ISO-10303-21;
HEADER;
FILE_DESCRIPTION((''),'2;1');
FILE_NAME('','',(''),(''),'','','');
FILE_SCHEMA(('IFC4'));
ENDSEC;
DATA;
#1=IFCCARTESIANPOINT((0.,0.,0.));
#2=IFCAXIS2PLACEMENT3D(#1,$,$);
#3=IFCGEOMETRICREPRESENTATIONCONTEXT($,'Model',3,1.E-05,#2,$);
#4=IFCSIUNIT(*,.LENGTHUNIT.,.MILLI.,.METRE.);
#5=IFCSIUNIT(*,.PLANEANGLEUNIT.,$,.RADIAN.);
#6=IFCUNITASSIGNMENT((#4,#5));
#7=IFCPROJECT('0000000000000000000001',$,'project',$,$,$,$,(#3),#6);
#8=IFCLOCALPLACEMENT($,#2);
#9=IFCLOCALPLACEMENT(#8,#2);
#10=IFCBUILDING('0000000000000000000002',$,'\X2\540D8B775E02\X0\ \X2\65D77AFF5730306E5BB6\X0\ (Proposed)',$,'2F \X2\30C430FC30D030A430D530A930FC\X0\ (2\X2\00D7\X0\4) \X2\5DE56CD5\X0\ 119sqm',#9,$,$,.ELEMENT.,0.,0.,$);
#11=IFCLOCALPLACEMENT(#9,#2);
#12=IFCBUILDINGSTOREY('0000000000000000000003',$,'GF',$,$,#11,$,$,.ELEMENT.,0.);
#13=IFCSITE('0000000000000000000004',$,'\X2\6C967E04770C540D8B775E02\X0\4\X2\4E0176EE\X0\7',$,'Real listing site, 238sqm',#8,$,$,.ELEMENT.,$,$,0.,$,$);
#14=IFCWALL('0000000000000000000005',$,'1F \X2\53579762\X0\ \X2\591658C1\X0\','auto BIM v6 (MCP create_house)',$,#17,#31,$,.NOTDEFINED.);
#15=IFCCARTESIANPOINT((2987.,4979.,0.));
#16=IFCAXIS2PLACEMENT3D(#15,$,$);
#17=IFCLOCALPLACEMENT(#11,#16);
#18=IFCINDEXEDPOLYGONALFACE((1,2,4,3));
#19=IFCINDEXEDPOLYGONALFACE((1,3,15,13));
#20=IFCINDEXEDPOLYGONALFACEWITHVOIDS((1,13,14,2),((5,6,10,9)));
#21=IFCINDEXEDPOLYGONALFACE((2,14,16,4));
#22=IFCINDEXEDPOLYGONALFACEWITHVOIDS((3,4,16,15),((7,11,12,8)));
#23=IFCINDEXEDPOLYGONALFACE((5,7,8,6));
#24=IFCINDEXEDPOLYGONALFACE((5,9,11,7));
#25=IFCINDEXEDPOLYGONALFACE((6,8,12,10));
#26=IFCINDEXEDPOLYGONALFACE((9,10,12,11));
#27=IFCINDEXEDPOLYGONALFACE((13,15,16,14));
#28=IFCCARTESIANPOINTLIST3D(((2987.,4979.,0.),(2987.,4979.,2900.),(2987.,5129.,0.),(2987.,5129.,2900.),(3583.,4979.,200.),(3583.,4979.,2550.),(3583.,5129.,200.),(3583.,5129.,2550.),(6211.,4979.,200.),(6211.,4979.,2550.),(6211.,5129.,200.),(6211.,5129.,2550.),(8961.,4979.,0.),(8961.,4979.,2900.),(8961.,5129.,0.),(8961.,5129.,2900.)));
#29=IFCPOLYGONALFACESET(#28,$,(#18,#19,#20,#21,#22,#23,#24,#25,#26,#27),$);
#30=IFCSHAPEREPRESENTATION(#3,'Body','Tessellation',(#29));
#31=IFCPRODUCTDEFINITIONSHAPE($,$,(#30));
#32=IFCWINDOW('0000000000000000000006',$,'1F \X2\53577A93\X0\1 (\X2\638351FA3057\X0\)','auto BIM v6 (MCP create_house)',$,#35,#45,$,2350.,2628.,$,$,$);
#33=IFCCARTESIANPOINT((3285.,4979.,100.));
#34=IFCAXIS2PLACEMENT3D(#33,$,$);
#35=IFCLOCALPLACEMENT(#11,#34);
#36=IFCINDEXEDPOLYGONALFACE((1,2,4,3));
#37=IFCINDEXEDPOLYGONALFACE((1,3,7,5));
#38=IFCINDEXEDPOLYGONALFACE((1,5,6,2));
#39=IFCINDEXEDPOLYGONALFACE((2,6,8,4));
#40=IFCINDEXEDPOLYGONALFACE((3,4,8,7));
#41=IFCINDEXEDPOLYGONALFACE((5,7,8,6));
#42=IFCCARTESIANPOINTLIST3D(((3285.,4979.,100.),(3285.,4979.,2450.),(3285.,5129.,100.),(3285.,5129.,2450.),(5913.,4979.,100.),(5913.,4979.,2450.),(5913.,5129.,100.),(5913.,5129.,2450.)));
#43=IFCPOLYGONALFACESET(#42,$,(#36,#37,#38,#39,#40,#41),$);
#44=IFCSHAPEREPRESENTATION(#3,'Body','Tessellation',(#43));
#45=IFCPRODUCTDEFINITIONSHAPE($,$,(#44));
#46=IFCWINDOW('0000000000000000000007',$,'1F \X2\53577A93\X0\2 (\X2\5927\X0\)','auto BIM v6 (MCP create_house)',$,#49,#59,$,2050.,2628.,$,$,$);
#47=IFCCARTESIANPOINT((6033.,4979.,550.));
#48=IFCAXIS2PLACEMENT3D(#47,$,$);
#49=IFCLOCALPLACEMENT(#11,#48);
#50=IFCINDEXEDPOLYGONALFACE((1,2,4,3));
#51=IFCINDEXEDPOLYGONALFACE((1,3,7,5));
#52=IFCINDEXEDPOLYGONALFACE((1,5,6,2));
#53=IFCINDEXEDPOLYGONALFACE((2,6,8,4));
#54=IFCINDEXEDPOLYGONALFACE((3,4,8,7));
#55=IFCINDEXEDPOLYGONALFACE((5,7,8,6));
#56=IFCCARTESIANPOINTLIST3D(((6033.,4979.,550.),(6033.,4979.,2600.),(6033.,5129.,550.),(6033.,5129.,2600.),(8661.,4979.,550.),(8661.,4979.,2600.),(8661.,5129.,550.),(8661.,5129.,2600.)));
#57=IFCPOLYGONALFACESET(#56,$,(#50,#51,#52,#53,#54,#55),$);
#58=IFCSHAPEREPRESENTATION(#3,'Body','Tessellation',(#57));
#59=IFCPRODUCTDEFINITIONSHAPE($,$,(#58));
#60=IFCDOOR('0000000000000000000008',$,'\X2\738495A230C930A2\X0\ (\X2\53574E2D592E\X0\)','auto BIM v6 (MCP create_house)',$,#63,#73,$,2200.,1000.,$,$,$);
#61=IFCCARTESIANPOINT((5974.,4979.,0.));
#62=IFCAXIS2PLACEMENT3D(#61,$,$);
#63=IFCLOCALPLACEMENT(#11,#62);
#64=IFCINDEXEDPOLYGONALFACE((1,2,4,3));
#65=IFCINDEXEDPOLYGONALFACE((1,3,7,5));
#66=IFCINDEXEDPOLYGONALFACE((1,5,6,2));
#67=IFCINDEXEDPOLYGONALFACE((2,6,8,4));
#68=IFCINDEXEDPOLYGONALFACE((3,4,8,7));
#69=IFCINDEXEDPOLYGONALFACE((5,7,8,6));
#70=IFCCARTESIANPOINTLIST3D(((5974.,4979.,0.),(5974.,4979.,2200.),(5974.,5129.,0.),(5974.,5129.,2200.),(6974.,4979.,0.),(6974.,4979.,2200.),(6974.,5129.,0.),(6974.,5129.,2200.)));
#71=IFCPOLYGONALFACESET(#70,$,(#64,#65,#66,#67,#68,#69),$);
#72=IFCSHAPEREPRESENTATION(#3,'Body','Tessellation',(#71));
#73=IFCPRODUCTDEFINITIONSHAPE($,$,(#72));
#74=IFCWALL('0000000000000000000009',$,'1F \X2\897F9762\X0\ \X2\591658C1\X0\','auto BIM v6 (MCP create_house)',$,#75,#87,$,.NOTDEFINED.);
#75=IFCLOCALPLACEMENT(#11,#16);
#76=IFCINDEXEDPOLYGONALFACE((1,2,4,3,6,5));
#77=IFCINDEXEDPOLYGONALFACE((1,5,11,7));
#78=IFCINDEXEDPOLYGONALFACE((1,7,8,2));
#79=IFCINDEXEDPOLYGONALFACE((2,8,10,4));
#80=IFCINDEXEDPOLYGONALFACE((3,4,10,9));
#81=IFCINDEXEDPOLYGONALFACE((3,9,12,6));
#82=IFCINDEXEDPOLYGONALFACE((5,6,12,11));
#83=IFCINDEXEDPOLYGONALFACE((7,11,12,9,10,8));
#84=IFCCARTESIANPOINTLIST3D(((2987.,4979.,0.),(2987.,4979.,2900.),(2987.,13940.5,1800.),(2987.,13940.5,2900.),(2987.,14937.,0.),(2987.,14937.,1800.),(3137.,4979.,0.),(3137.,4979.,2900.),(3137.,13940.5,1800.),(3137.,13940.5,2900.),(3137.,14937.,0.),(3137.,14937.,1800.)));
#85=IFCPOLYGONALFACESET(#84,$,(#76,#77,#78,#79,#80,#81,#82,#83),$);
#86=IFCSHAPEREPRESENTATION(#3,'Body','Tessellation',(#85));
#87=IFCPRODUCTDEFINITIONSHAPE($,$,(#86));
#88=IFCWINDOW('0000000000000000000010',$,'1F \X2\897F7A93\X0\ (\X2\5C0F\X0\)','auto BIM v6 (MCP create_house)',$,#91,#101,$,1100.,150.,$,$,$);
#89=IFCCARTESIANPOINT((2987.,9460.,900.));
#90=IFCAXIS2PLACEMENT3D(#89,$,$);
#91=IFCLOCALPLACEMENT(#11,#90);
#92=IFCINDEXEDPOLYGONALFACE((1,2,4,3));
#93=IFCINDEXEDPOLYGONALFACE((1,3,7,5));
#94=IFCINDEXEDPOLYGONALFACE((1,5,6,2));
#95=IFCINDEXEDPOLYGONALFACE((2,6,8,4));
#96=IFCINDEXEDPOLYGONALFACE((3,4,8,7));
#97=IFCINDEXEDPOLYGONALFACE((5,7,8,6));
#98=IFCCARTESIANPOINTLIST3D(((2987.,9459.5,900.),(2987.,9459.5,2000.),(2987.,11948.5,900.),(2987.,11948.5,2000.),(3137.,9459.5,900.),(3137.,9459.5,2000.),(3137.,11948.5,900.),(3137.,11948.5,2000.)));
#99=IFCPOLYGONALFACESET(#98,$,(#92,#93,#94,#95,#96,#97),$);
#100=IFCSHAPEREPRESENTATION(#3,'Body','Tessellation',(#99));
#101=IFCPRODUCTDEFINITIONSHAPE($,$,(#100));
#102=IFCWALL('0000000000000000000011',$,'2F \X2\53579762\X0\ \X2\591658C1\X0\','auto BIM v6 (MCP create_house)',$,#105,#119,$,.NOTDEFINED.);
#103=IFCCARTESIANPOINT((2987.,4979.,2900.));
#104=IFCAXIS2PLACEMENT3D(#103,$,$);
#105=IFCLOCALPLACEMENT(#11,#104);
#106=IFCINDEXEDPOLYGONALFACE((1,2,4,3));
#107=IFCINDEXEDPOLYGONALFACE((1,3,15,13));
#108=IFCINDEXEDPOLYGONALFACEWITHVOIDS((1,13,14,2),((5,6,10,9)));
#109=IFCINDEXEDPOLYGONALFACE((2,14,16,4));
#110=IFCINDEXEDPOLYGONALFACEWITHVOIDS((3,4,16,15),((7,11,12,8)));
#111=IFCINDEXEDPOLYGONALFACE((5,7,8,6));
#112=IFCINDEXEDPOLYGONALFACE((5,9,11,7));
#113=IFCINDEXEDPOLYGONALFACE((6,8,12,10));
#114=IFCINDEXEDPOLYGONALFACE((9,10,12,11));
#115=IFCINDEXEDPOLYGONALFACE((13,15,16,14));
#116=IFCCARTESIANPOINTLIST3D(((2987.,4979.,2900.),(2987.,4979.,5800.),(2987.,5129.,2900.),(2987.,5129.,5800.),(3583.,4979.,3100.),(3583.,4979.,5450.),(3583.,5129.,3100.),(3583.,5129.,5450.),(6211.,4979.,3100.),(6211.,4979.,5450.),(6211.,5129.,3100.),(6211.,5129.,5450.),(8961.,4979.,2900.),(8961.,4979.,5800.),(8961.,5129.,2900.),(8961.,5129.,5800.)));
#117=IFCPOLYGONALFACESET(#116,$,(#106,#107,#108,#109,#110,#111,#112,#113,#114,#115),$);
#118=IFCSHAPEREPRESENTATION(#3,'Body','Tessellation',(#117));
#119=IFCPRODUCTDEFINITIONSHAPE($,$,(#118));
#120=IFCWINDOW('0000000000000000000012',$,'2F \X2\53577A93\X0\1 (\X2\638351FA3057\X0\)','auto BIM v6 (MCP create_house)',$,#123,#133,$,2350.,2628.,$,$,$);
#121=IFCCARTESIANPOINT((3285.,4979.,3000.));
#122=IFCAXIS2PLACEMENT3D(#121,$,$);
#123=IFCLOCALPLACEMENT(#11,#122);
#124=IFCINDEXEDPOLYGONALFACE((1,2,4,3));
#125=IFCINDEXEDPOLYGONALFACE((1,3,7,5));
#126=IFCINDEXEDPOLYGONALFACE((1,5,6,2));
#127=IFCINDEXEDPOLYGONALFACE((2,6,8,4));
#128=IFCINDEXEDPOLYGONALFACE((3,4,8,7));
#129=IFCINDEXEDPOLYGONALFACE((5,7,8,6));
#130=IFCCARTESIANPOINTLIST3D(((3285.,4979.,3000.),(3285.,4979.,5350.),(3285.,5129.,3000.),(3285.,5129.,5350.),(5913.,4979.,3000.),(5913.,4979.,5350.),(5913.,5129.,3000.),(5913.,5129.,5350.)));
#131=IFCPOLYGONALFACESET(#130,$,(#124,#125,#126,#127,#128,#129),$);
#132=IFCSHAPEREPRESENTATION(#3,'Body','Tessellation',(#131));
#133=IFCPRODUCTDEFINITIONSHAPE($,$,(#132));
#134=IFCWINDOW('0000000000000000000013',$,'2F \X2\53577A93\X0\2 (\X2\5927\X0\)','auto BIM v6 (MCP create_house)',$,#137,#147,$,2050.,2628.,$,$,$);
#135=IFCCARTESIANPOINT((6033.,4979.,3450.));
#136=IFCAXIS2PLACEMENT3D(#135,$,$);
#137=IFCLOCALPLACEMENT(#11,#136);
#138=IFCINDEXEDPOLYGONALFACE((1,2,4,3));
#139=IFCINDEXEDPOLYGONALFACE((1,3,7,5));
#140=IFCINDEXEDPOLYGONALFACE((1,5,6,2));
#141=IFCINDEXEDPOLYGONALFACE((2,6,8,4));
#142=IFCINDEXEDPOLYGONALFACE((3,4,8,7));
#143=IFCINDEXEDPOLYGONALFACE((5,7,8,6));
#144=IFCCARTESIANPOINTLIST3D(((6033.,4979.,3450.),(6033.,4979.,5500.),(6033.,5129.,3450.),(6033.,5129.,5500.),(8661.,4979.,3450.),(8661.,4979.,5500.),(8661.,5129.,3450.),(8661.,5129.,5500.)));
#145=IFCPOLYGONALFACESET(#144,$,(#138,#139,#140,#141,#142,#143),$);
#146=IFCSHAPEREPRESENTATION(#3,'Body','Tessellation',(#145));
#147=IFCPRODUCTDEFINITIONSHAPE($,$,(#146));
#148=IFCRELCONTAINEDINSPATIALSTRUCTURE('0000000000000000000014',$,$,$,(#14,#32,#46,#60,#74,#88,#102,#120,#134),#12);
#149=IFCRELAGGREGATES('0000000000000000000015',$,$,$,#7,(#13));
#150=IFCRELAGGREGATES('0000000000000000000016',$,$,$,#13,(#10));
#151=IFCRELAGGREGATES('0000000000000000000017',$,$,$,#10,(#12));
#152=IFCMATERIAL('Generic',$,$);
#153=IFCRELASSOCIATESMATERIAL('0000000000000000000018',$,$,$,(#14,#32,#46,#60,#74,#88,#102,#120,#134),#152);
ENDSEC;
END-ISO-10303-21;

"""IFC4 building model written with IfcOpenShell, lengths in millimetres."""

from ifc_helpers import new_model, si_unit, frame, frame_2d, origin, place, context, project, spatial, rectangle, extrude, material, element, fill, save


model = new_model("IFC4")

# Units and contexts
model_context = context("Model", 3, precision=1e-05, world=origin())
ifc_project = project(units=[si_unit("LENGTHUNIT", "METRE", prefix="MILLI"), si_unit("PLANEANGLEUNIT", "RADIAN")], contexts=[model_context])

# Site, building, storey
site_placement = place(None, origin())
site = spatial("IfcSite", under=ifc_project, at=site_placement, Name="沖縄県名護市4丁目7", ObjectType="Real listing site, 238sqm", CompositionType="ELEMENT", RefElevation=0.0)
building_placement = place(site_placement, origin())
building = spatial("IfcBuilding", under=site, at=building_placement, Name="名護市 旗竿地の家 (Proposed)", ObjectType="2F ツーバイフォー (2×4) 工法 119sqm", CompositionType="ELEMENT", ElevationOfRefHeight=0.0, ElevationOfTerrain=0.0)
storey_placement = place(building_placement, origin())
storey = spatial("IfcBuildingStorey", under=building, at=storey_placement, Name="GF", CompositionType="ELEMENT", Elevation=0.0)

# Shared definitions
ifc_material = material(Name="Generic")

# Wall, openings, windows, door
wall_1_placement = place(storey_placement, frame((2987.0, 4979.0, 0.0)))
wall_1 = element("IfcWall", 1, at=wall_1_placement, inside=storey, material=ifc_material, Name="1F 南面 外壁", Description="auto BIM v6 (MCP create_house)", PredefinedType="NOTDEFINED", context=model_context, shape_type="SweptSolid", body=[
    extrude(rectangle(XDim=5974.0, YDim=150.0, at=frame_2d((2987.0, 75.0))), frame((2987.0, 4979.0, 0.0)), (0.0, 0.0, 1.0), 2900.0),
])
opening_1_placement = place(storey_placement, frame((3285.0, 4979.0, 100.0)))
opening_1 = element("IfcOpeningElement", 2, at=opening_1_placement, cuts=wall_1, PredefinedType="NOTDEFINED", context=model_context, shape_type="SweptSolid", body=[
    extrude(rectangle(XDim=2628.0, YDim=150.0, at=frame_2d((1314.0, 75.0))), frame((3285.0, 4979.0, 100.0)), (0.0, 0.0, 1.0), 2350.0),
])
opening_2_placement = place(storey_placement, frame((6033.0, 4979.0, 550.0)))
opening_2 = element("IfcOpeningElement", 3, at=opening_2_placement, cuts=wall_1, PredefinedType="NOTDEFINED", context=model_context, shape_type="SweptSolid", body=[
    extrude(rectangle(XDim=2628.0, YDim=150.0, at=frame_2d((1314.0, 75.0))), frame((6033.0, 4979.0, 550.0)), (0.0, 0.0, 1.0), 2050.0),
])
opening_3_placement = place(storey_placement, frame((5974.0, 4979.0, 0.0)))
opening_3 = element("IfcOpeningElement", 4, at=opening_3_placement, cuts=wall_1, PredefinedType="NOTDEFINED", context=model_context, shape_type="SweptSolid", body=[
    extrude(rectangle(XDim=1000.0, YDim=150.0, at=frame_2d((500.0, 75.0))), frame((5974.0, 4979.0, 0.0)), (0.0, 0.0, 1.0), 2200.0),
])
window_1_placement = place(storey_placement, frame((3285.0, 4979.0, 100.0)))
window_1 = element("IfcWindow", 5, at=window_1_placement, inside=storey, material=ifc_material, Name="1F 南窓1 (掃出し)", Description="auto BIM v6 (MCP create_house)", OverallHeight=2350.0, OverallWidth=2628.0, context=model_context, shape_type="SweptSolid", body=[
    extrude(rectangle(XDim=2628.0, YDim=150.0, at=frame_2d((1314.0, 75.0))), frame((3285.0, 4979.0, 100.0)), (0.0, 0.0, 1.0), 2350.0),
])
fill(opening_1, window_1)
window_2_placement = place(storey_placement, frame((6033.0, 4979.0, 550.0)))
window_2 = element("IfcWindow", 6, at=window_2_placement, inside=storey, material=ifc_material, Name="1F 南窓2 (大)", Description="auto BIM v6 (MCP create_house)", OverallHeight=2050.0, OverallWidth=2628.0, context=model_context, shape_type="SweptSolid", body=[
    extrude(rectangle(XDim=2628.0, YDim=150.0, at=frame_2d((1314.0, 75.0))), frame((6033.0, 4979.0, 550.0)), (0.0, 0.0, 1.0), 2050.0),
])
fill(opening_2, window_2)
door_placement = place(storey_placement, frame((5974.0, 4979.0, 0.0)))
door = element("IfcDoor", 7, at=door_placement, inside=storey, material=ifc_material, Name="玄関ドア (南中央)", Description="auto BIM v6 (MCP create_house)", OverallHeight=2200.0, OverallWidth=1000.0, context=model_context, shape_type="SweptSolid", body=[
    extrude(rectangle(XDim=1000.0, YDim=150.0, at=frame_2d((500.0, 75.0))), frame((5974.0, 4979.0, 0.0)), (0.0, 0.0, 1.0), 2200.0),
])
fill(opening_3, door)

# Wall, opening, window
wall_2_placement = place(storey_placement, frame((2987.0, 4979.0, 0.0)))
wall_2 = element("IfcWall", 8, at=wall_2_placement, inside=storey, material=ifc_material, Name="1F 西面 外壁", Description="auto BIM v6 (MCP create_house)", PredefinedType="NOTDEFINED", context=model_context, shape_type="SweptSolid", body=[
    extrude(rectangle(XDim=150.0, YDim=9958.0, at=frame_2d((75.0, 4979.0))), frame((2987.0, 4979.0, 0.0)), (0.0, 0.0, 1.0), 2900.0),
])
opening_4_placement = place(storey_placement, frame((2987.0, 9460.0, 900.0)))
opening_4 = element("IfcOpeningElement", 9, at=opening_4_placement, cuts=wall_2, PredefinedType="NOTDEFINED", context=model_context, shape_type="SweptSolid", body=[
    extrude(rectangle(XDim=150.0, YDim=2489.0, at=frame_2d((75.0, 1244.0))), frame((2987.0, 9460.0, 900.0)), (0.0, 0.0, 1.0), 1100.0),
])
window_3_placement = place(storey_placement, frame((2987.0, 9460.0, 900.0)))
window_3 = element("IfcWindow", 10, at=window_3_placement, inside=storey, material=ifc_material, Name="1F 西窓 (小)", Description="auto BIM v6 (MCP create_house)", OverallHeight=1100.0, OverallWidth=150.0, context=model_context, shape_type="SweptSolid", body=[
    extrude(rectangle(XDim=150.0, YDim=2489.0, at=frame_2d((75.0, 1244.0))), frame((2987.0, 9460.0, 900.0)), (0.0, 0.0, 1.0), 1100.0),
])
fill(opening_4, window_3)

# Wall, openings, windows
wall_3_placement = place(storey_placement, frame((2987.0, 4979.0, 2900.0)))
wall_3 = element("IfcWall", 11, at=wall_3_placement, inside=storey, material=ifc_material, Name="2F 南面 外壁", Description="auto BIM v6 (MCP create_house)", PredefinedType="NOTDEFINED", context=model_context, shape_type="SweptSolid", body=[
    extrude(rectangle(XDim=5974.0, YDim=150.0, at=frame_2d((2987.0, 75.0))), frame((2987.0, 4979.0, 2900.0)), (0.0, 0.0, 1.0), 2900.0),
])
opening_5_placement = place(storey_placement, frame((3285.0, 4979.0, 3000.0)))
opening_5 = element("IfcOpeningElement", 12, at=opening_5_placement, cuts=wall_3, PredefinedType="NOTDEFINED", context=model_context, shape_type="SweptSolid", body=[
    extrude(rectangle(XDim=2628.0, YDim=150.0, at=frame_2d((1314.0, 75.0))), frame((3285.0, 4979.0, 3000.0)), (0.0, 0.0, 1.0), 2350.0),
])
opening_6_placement = place(storey_placement, frame((6033.0, 4979.0, 3450.0)))
opening_6 = element("IfcOpeningElement", 13, at=opening_6_placement, cuts=wall_3, PredefinedType="NOTDEFINED", context=model_context, shape_type="SweptSolid", body=[
    extrude(rectangle(XDim=2628.0, YDim=150.0, at=frame_2d((1314.0, 75.0))), frame((6033.0, 4979.0, 3450.0)), (0.0, 0.0, 1.0), 2050.0),
])
window_4_placement = place(storey_placement, frame((3285.0, 4979.0, 3000.0)))
window_4 = element("IfcWindow", 14, at=window_4_placement, inside=storey, material=ifc_material, Name="2F 南窓1 (掃出し)", Description="auto BIM v6 (MCP create_house)", OverallHeight=2350.0, OverallWidth=2628.0, context=model_context, shape_type="SweptSolid", body=[
    extrude(rectangle(XDim=2628.0, YDim=150.0, at=frame_2d((1314.0, 75.0))), frame((3285.0, 4979.0, 3000.0)), (0.0, 0.0, 1.0), 2350.0),
])
fill(opening_5, window_4)
window_5_placement = place(storey_placement, frame((6033.0, 4979.0, 3450.0)))
window_5 = element("IfcWindow", 15, at=window_5_placement, inside=storey, material=ifc_material, Name="2F 南窓2 (大)", Description="auto BIM v6 (MCP create_house)", OverallHeight=2050.0, OverallWidth=2628.0, context=model_context, shape_type="SweptSolid", body=[
    extrude(rectangle(XDim=2628.0, YDim=150.0, at=frame_2d((1314.0, 75.0))), frame((6033.0, 4979.0, 3450.0)), (0.0, 0.0, 1.0), 2050.0),
])
fill(opening_6, window_5)

save(model, "model.ifc")
